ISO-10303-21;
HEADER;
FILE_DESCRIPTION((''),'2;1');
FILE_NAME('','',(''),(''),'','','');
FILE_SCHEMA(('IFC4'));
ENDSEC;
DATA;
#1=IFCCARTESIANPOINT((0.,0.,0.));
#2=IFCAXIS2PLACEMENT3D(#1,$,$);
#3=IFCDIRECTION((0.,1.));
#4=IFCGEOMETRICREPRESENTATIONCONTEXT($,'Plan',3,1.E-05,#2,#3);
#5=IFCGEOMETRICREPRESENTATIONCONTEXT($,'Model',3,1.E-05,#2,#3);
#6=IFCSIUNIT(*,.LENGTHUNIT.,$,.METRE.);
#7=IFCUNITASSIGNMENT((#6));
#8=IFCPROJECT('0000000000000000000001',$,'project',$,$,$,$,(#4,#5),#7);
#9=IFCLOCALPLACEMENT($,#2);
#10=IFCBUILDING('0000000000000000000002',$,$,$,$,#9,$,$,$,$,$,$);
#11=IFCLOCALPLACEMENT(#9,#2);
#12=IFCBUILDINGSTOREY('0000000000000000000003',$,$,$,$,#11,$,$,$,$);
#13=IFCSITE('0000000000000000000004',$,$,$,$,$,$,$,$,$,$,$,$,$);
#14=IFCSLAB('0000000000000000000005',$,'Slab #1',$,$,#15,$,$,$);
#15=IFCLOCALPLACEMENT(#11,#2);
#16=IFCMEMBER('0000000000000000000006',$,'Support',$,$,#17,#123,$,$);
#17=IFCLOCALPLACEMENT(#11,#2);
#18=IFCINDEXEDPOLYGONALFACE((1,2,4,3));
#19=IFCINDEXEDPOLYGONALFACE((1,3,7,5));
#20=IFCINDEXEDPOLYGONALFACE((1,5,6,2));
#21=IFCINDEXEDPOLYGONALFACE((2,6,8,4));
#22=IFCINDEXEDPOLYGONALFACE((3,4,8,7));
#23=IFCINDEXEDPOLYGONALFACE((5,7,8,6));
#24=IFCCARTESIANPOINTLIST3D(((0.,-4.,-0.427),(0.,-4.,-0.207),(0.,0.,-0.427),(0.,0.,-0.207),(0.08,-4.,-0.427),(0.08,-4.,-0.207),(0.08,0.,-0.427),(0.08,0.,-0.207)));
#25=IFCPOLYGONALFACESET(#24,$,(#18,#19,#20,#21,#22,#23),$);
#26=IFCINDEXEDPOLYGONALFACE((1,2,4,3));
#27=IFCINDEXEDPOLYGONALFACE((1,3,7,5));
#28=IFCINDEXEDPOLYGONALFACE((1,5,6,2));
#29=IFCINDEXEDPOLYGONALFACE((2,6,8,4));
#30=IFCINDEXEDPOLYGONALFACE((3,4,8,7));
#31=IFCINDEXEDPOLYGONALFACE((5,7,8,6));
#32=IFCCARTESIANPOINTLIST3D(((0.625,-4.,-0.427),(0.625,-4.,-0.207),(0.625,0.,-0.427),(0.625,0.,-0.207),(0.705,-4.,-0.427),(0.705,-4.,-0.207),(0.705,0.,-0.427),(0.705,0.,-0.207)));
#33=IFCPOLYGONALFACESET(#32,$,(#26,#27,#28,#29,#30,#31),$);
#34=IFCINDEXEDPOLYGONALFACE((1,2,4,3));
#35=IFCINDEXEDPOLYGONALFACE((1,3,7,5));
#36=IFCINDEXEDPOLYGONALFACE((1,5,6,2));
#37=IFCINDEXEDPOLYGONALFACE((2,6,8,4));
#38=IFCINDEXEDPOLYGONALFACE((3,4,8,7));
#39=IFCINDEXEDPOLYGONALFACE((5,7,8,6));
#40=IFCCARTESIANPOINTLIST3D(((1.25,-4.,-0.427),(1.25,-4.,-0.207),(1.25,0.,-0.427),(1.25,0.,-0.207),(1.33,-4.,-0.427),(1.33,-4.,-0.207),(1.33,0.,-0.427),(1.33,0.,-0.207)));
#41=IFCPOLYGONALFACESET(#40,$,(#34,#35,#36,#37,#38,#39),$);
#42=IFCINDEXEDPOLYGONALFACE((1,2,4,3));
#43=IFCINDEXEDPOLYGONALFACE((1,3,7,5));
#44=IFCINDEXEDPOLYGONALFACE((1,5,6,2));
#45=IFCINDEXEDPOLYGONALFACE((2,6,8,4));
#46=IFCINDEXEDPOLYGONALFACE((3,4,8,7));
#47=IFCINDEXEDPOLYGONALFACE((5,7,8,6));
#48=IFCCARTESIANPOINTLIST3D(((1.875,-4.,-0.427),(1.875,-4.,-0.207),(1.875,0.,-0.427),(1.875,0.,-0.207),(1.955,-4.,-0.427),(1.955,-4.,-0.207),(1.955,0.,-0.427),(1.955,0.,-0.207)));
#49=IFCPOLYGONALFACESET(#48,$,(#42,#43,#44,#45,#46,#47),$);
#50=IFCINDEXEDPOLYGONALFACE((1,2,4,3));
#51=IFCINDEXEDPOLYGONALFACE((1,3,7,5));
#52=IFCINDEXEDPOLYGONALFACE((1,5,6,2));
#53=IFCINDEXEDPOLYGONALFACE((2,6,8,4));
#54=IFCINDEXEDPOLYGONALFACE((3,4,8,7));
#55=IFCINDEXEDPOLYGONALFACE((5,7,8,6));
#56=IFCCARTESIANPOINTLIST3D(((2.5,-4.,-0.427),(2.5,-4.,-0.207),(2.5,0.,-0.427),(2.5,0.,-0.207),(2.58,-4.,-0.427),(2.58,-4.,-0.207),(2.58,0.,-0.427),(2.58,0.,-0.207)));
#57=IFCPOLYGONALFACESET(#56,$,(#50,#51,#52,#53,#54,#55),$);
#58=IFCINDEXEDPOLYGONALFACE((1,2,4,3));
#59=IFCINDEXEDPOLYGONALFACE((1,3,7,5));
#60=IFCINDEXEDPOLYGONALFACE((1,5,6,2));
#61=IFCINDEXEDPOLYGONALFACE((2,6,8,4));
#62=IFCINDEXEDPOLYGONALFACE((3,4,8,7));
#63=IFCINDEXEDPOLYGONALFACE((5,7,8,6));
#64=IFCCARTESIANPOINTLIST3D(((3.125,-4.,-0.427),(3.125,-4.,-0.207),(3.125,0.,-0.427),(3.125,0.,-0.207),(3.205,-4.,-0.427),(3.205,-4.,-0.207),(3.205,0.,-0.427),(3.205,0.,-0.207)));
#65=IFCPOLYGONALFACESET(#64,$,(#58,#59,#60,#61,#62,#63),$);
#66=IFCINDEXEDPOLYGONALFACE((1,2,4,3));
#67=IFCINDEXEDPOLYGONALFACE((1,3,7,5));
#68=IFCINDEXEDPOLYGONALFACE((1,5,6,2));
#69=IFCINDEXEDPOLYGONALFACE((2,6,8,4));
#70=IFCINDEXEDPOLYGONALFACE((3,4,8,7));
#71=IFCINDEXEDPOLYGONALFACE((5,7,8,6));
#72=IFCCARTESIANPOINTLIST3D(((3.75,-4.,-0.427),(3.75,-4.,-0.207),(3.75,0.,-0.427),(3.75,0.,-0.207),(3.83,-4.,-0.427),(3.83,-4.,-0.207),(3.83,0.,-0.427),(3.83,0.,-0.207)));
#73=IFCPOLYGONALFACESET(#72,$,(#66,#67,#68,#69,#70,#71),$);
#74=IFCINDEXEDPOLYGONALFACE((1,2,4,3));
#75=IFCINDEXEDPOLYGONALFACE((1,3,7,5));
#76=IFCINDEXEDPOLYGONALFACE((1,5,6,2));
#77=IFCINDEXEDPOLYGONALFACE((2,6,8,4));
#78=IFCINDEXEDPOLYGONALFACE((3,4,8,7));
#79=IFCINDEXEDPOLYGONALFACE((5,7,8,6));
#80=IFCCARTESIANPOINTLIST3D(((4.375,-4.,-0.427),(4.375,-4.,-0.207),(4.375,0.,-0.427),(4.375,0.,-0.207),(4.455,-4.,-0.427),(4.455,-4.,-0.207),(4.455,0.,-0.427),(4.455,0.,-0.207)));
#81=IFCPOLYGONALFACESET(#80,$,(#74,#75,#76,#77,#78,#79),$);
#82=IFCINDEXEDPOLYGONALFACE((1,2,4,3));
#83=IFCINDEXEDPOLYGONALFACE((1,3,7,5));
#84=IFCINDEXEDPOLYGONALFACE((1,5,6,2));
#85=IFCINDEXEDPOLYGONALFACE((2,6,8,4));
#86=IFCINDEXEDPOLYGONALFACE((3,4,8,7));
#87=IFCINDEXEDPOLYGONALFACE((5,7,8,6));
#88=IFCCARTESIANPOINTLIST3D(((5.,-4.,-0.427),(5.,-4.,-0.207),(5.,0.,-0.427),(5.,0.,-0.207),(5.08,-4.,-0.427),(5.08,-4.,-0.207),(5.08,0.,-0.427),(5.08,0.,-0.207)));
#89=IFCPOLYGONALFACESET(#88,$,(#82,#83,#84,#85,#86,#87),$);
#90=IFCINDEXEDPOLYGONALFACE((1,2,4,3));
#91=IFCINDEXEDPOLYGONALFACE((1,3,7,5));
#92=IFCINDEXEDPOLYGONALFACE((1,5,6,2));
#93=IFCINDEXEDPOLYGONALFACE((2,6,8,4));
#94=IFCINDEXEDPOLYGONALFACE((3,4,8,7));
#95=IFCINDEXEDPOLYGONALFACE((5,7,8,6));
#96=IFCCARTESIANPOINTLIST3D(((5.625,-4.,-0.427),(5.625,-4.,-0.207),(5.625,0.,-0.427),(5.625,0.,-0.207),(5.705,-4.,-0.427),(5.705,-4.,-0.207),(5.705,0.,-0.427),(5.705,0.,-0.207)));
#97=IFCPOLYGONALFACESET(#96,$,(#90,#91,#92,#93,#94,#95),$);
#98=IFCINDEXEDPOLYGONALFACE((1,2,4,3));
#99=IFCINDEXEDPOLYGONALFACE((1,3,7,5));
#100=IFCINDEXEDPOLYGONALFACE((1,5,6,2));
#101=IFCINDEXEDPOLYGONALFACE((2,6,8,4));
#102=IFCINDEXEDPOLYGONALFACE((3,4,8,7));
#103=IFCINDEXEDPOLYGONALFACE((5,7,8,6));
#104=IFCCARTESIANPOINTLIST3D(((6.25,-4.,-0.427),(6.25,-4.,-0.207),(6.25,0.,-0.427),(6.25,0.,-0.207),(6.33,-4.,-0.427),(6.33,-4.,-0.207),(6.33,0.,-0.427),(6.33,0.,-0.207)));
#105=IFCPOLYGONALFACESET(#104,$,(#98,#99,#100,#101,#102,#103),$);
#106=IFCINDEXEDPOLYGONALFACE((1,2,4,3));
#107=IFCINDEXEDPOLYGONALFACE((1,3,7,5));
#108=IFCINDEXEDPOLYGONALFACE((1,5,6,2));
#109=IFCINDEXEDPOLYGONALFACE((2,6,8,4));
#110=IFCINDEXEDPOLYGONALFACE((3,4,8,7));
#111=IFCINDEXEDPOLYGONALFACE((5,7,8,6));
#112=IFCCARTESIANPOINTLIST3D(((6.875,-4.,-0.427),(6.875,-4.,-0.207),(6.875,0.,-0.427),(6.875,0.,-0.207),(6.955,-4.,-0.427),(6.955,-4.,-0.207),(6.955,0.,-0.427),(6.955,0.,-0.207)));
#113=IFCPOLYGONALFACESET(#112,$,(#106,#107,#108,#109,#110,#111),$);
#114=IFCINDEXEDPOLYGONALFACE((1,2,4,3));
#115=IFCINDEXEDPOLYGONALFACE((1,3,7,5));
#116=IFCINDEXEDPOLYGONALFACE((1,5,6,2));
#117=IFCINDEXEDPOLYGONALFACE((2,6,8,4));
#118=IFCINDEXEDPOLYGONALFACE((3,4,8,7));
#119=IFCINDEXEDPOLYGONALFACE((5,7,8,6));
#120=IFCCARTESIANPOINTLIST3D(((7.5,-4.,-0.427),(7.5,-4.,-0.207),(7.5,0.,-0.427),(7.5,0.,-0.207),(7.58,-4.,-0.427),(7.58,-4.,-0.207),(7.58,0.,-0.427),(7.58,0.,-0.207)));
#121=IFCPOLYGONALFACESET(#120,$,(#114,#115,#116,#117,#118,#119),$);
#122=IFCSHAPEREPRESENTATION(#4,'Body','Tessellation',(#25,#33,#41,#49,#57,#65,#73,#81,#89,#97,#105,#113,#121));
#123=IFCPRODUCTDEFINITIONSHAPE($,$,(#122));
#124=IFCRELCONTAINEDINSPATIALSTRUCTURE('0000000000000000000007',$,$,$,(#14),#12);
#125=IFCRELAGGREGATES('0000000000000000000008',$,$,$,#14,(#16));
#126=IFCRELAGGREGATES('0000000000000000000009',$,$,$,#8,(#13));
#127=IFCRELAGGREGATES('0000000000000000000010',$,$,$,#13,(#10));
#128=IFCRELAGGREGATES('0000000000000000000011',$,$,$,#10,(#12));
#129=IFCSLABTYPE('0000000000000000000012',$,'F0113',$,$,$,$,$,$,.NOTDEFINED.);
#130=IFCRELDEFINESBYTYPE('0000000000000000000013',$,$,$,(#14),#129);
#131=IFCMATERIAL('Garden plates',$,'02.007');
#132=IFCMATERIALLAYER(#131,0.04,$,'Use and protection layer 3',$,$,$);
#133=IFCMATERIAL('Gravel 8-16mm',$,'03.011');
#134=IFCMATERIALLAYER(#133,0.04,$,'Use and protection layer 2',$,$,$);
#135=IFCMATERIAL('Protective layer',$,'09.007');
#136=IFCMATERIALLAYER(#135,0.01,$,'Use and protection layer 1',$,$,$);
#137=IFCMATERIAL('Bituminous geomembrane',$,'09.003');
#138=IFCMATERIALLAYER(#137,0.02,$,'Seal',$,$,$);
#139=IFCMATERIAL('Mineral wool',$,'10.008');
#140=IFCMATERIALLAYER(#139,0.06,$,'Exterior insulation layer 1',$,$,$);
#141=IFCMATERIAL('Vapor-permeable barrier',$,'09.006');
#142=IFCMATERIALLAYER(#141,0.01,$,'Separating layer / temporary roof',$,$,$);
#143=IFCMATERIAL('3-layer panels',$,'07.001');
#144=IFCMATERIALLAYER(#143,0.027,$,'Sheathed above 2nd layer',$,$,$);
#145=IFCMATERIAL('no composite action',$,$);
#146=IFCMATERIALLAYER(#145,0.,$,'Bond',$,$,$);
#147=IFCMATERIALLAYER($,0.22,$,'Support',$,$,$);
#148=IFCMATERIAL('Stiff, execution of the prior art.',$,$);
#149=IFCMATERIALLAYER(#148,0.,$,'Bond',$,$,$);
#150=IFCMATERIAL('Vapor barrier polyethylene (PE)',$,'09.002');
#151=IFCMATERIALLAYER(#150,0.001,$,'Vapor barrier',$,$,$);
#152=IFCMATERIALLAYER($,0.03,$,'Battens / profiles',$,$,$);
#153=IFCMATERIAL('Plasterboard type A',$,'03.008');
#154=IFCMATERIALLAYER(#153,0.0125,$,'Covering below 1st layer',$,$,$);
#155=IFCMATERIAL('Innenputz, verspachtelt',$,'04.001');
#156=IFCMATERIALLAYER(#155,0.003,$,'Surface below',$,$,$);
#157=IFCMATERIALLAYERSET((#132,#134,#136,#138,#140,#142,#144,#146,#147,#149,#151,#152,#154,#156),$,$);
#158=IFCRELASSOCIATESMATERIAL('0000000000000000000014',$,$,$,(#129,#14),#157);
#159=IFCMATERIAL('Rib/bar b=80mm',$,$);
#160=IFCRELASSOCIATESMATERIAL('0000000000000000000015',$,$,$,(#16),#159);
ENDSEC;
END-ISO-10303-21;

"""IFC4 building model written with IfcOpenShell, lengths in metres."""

from ifc_helpers import new_model, si_unit, direction, frame, frame_2d, origin, place, context, project, spatial, rectangle, extrude, material, layer, layer_set, type_object, element, aggregate, save


model = new_model("IFC4")

# Units and contexts
plan_context = context("Plan", 3, precision=1e-05, world=origin(), true_north=direction((0.0, 1.0)))
model_context = context("Model", 3, precision=1e-05, world=origin(), true_north=direction((0.0, 1.0)))
ifc_project = project(units=[si_unit("LENGTHUNIT", "METRE")], contexts=[plan_context, model_context])

# Site, building, storey
site = spatial("IfcSite", under=ifc_project)
building_placement = place(None, origin())
building = spatial("IfcBuilding", under=site, at=building_placement)
storey_placement = place(building_placement, origin())
storey = spatial("IfcBuildingStorey", under=building, at=storey_placement)

# Slab, member
ifc_material_1 = material(Name="Garden plates", Category="02.007")
ifc_layer_1 = layer(ifc_material_1, 0.04, Name="Use and protection layer 3")
ifc_material_2 = material(Name="Gravel 8-16mm", Category="03.011")
ifc_layer_2 = layer(ifc_material_2, 0.04, Name="Use and protection layer 2")
ifc_material_3 = material(Name="Protective layer", Category="09.007")
ifc_layer_3 = layer(ifc_material_3, 0.01, Name="Use and protection layer 1")
ifc_material_4 = material(Name="Bituminous geomembrane", Category="09.003")
ifc_layer_4 = layer(ifc_material_4, 0.02, Name="Seal")
ifc_material_5 = material(Name="Mineral wool", Category="10.008")
ifc_layer_5 = layer(ifc_material_5, 0.06, Name="Exterior insulation layer 1")
ifc_material_6 = material(Name="Vapor-permeable barrier", Category="09.006")
ifc_layer_6 = layer(ifc_material_6, 0.01, Name="Separating layer / temporary roof")
ifc_material_7 = material(Name="3-layer panels", Category="07.001")
ifc_layer_7 = layer(ifc_material_7, 0.027, Name="Sheathed above 2nd layer")
ifc_material_8 = material(Name="no composite action")
ifc_layer_8 = layer(ifc_material_8, 0.0, Name="Bond")
ifc_layer_9 = layer(None, 0.22, Name="Support")
ifc_material_9 = material(Name="Stiff, execution of the prior art.")
ifc_layer_10 = layer(ifc_material_9, 0.0, Name="Bond")
ifc_material_10 = material(Name="Vapor barrier polyethylene (PE)", Category="09.002")
ifc_layer_11 = layer(ifc_material_10, 0.001, Name="Vapor barrier")
ifc_layer_12 = layer(None, 0.03, Name="Battens / profiles")
ifc_material_11 = material(Name="Plasterboard type A", Category="03.008")
ifc_layer_13 = layer(ifc_material_11, 0.0125, Name="Covering below 1st layer")
ifc_material_12 = material(Name="Innenputz, verspachtelt", Category="04.001")
ifc_layer_14 = layer(ifc_material_12, 0.003, Name="Surface below")
ifc_layer_set = layer_set([ifc_layer_1, ifc_layer_2, ifc_layer_3, ifc_layer_4, ifc_layer_5, ifc_layer_6, ifc_layer_7, ifc_layer_8, ifc_layer_9, ifc_layer_10, ifc_layer_11, ifc_layer_12, ifc_layer_13, ifc_layer_14])
slab_type = type_object("IfcSlabType", Name="F0113", PredefinedType="NOTDEFINED", material=ifc_layer_set)
slab_placement = place(None, frame((0.0, 0.0, 0.0), z_axis=(0.0, 0.0, -1.0), x_axis=(1.0, 0.0, 0.0)))
slab = element("IfcSlab", 1, at=slab_placement, inside=storey, type_object=slab_type, material=ifc_layer_set, Name="Slab #1")
ifc_material_13 = material(Name="Rib/bar b=80mm")
member_1_placement = place(slab_placement, origin())
member_1 = element("IfcMember", 2, at=member_1_placement, material=ifc_material_13, Name="Support", context=plan_context, shape_type="SweptSolid", body=[
    extrude(rectangle(XDim=0.08, YDim=0.22, at=frame_2d((0.04, 0.11), x_axis=(1.0, 0.0))), frame((0.0, 4.0, 0.207), z_axis=(0.0, -1.0, 0.0), x_axis=(1.0, 0.0, 0.0)), (0.0, 0.0, 1.0), 4.0),
    extrude(rectangle(XDim=0.08, YDim=0.22, at=frame_2d((0.04, 0.11), x_axis=(1.0, 0.0))), frame((0.625, 4.0, 0.207), z_axis=(0.0, -1.0, 0.0), x_axis=(1.0, 0.0, 0.0)), (0.0, 0.0, 1.0), 4.0),
    extrude(rectangle(XDim=0.08, YDim=0.22, at=frame_2d((0.04, 0.11), x_axis=(1.0, 0.0))), frame((1.25, 4.0, 0.207), z_axis=(0.0, -1.0, 0.0), x_axis=(1.0, 0.0, 0.0)), (0.0, 0.0, 1.0), 4.0),
    extrude(rectangle(XDim=0.08, YDim=0.22, at=frame_2d((0.04, 0.11), x_axis=(1.0, 0.0))), frame((1.875, 4.0, 0.207), z_axis=(0.0, -1.0, 0.0), x_axis=(1.0, 0.0, 0.0)), (0.0, 0.0, 1.0), 4.0),
    extrude(rectangle(XDim=0.08, YDim=0.22, at=frame_2d((0.04, 0.11), x_axis=(1.0, 0.0))), frame((2.5, 4.0, 0.207), z_axis=(0.0, -1.0, 0.0), x_axis=(1.0, 0.0, 0.0)), (0.0, 0.0, 1.0), 4.0),
    extrude(rectangle(XDim=0.08, YDim=0.22, at=frame_2d((0.04, 0.11), x_axis=(1.0, 0.0))), frame((3.125, 4.0, 0.207), z_axis=(0.0, -1.0, 0.0), x_axis=(1.0, 0.0, 0.0)), (0.0, 0.0, 1.0), 4.0),
    extrude(rectangle(XDim=0.08, YDim=0.22, at=frame_2d((0.04, 0.11), x_axis=(1.0, 0.0))), frame((3.75, 4.0, 0.207), z_axis=(0.0, -1.0, 0.0), x_axis=(1.0, 0.0, 0.0)), (0.0, 0.0, 1.0), 4.0),
    extrude(rectangle(XDim=0.08, YDim=0.22, at=frame_2d((0.04, 0.11), x_axis=(1.0, 0.0))), frame((4.375, 4.0, 0.207), z_axis=(0.0, -1.0, 0.0), x_axis=(1.0, 0.0, 0.0)), (0.0, 0.0, 1.0), 4.0),
    extrude(rectangle(XDim=0.08, YDim=0.22, at=frame_2d((0.04, 0.11), x_axis=(1.0, 0.0))), frame((5.0, 4.0, 0.207), z_axis=(0.0, -1.0, 0.0), x_axis=(1.0, 0.0, 0.0)), (0.0, 0.0, 1.0), 4.0),
    extrude(rectangle(XDim=0.08, YDim=0.22, at=frame_2d((0.04, 0.11), x_axis=(1.0, 0.0))), frame((5.625, 4.0, 0.207), z_axis=(0.0, -1.0, 0.0), x_axis=(1.0, 0.0, 0.0)), (0.0, 0.0, 1.0), 4.0),
    extrude(rectangle(XDim=0.08, YDim=0.22, at=frame_2d((0.04, 0.11), x_axis=(1.0, 0.0))), frame((6.25, 4.0, 0.207), z_axis=(0.0, -1.0, 0.0), x_axis=(1.0, 0.0, 0.0)), (0.0, 0.0, 1.0), 4.0),
    extrude(rectangle(XDim=0.08, YDim=0.22, at=frame_2d((0.04, 0.11), x_axis=(1.0, 0.0))), frame((6.875, 4.0, 0.207), z_axis=(0.0, -1.0, 0.0), x_axis=(1.0, 0.0, 0.0)), (0.0, 0.0, 1.0), 4.0),
    extrude(rectangle(XDim=0.08, YDim=0.22, at=frame_2d((0.04, 0.11), x_axis=(1.0, 0.0))), frame((7.5, 4.0, 0.207), z_axis=(0.0, -1.0, 0.0), x_axis=(1.0, 0.0, 0.0)), (0.0, 0.0, 1.0), 4.0),
])
aggregate(slab, [member_1])

save(model, "model.ifc")
